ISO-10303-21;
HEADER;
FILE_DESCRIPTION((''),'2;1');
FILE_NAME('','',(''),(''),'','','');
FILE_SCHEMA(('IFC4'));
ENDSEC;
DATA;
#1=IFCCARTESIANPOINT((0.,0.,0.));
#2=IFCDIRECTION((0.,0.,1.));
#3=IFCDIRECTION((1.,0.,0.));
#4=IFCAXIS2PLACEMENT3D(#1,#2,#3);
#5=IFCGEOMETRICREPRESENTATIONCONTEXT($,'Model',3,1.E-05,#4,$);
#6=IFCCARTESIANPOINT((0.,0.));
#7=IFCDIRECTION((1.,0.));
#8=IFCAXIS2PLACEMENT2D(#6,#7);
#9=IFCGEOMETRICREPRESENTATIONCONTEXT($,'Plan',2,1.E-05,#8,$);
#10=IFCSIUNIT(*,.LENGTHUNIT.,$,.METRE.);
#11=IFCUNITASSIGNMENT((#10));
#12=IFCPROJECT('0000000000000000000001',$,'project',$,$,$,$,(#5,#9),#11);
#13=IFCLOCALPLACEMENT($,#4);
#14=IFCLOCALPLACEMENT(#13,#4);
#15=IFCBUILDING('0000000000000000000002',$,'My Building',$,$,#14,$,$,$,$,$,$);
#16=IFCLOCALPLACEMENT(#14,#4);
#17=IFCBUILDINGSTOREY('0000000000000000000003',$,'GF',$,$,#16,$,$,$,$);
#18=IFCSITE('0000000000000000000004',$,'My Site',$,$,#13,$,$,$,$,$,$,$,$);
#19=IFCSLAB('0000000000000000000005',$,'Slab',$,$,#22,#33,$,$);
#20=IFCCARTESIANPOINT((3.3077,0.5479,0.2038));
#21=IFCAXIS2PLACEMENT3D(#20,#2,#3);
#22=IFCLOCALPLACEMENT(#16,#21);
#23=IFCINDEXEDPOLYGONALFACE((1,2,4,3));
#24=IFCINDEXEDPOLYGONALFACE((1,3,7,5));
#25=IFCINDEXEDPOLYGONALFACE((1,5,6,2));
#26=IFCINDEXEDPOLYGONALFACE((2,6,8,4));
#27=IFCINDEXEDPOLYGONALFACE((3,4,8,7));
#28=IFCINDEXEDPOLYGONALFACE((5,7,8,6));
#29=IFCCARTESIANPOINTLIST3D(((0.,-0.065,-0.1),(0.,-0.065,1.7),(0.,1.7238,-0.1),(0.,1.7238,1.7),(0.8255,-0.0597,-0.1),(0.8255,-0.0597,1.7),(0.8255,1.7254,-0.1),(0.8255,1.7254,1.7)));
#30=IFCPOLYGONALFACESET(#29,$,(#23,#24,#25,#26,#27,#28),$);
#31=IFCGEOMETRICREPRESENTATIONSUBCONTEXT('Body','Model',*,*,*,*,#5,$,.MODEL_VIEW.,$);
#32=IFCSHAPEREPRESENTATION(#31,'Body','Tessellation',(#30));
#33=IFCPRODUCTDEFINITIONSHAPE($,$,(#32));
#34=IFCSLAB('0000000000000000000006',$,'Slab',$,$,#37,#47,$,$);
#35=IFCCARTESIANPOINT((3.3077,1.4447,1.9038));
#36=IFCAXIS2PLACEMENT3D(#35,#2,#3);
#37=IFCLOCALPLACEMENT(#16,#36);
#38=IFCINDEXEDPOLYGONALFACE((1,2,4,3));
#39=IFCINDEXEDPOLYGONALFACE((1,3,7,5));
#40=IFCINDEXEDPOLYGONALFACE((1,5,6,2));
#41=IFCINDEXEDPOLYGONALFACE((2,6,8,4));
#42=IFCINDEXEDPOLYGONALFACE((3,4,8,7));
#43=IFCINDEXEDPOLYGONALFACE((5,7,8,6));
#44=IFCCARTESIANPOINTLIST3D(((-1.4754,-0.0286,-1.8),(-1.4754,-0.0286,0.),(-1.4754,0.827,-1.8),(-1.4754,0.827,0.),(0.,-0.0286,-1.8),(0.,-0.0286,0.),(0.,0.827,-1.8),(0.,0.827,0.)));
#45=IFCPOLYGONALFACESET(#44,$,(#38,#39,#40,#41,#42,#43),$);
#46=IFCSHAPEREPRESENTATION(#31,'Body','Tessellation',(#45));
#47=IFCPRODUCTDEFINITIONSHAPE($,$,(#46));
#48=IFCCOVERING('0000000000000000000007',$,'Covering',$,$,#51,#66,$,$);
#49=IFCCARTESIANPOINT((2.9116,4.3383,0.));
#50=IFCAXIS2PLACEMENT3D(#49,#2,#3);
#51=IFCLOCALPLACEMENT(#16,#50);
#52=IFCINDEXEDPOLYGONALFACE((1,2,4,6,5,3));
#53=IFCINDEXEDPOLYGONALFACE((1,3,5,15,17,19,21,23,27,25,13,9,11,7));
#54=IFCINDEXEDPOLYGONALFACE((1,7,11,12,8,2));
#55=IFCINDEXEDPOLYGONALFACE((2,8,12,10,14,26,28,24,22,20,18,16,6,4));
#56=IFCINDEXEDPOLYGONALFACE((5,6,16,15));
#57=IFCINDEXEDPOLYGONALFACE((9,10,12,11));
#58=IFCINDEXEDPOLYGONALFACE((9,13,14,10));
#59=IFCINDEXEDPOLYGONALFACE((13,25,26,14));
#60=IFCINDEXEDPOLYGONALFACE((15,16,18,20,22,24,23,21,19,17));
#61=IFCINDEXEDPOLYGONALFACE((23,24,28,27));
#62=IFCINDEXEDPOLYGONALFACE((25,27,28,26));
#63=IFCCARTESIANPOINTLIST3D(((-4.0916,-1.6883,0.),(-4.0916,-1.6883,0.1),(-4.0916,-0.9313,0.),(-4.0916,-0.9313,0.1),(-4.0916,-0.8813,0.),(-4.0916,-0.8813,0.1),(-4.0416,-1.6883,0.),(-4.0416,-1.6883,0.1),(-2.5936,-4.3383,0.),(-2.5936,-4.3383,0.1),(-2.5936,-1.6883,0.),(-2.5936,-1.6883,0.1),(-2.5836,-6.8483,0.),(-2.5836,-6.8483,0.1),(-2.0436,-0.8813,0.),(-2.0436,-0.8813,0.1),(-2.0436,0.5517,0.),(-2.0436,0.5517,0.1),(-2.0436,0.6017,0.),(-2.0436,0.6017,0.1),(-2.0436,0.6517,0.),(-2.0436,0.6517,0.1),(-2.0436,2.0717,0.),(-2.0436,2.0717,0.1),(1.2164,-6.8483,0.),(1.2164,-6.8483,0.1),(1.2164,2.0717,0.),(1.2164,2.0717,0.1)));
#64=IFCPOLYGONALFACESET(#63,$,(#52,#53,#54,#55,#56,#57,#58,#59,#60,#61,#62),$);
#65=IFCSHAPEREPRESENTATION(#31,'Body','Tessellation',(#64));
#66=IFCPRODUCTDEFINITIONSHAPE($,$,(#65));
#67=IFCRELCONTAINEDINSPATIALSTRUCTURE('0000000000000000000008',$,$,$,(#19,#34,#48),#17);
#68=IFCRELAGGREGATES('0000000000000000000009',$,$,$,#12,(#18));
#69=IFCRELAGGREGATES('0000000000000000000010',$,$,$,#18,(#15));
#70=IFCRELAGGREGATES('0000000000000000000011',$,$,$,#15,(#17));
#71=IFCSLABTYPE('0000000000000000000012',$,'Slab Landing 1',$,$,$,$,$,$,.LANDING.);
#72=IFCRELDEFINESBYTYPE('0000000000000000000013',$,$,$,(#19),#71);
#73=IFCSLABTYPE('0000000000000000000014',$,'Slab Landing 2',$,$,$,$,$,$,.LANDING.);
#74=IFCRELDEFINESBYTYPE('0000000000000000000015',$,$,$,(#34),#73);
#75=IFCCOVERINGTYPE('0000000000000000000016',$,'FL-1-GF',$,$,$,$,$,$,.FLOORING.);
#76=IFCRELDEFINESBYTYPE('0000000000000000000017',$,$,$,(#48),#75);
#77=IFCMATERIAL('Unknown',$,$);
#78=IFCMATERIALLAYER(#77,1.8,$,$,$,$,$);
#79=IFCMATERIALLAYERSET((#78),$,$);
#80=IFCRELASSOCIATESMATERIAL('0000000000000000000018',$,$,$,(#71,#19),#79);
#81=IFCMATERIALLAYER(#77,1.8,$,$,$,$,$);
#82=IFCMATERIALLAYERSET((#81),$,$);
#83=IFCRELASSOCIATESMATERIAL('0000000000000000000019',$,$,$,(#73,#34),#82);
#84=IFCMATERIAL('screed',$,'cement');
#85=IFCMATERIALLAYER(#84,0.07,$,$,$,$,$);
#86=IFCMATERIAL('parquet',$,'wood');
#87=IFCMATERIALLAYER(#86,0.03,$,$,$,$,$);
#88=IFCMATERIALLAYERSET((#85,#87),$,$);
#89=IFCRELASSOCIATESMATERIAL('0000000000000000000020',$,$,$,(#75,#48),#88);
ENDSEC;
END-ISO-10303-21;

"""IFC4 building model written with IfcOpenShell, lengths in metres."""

from ifc_helpers import new_model, si_unit, frame, origin_with_axes, origin_2d_with_axis, place, context, subcontext, project, spatial, line, indexed_curve, outline, extrude, material, layer, layer_set, layer_usage, type_object, element, save


model = new_model("IFC4")

# Units and contexts
model_context = context("Model", 3, precision=1e-05, world=origin_with_axes())
plan_context = context("Plan", 2, precision=1e-05, world=origin_2d_with_axis())
body_context_1 = subcontext(model_context, "Body", "Model", "MODEL_VIEW")
ifc_project = project(units=[si_unit("LENGTHUNIT", "METRE")], contexts=[model_context, plan_context])

# Site, building, storey
site_placement = place(None, origin_with_axes())
site = spatial("IfcSite", under=ifc_project, at=site_placement, Name="My Site")
building_placement = place(site_placement, origin_with_axes())
building = spatial("IfcBuilding", under=site, at=building_placement, Name="My Building")
storey_placement = place(building_placement, origin_with_axes())
storey = spatial("IfcBuildingStorey", under=building, at=storey_placement, Name="GF")

# Slabs
ifc_material_1 = material(Name="Unknown")
ifc_layer_1 = layer(ifc_material_1, 1.8)
ifc_layer_set_1 = layer_set([ifc_layer_1])
ifc_layer_usage_1 = layer_usage(ifc_layer_set_1, "AXIS3", "POSITIVE", -0.1)
slab_type_1 = type_object("IfcSlabType", Name="Slab Landing 1", PredefinedType="LANDING", material=ifc_layer_set_1)
slab_1_placement = place(storey_placement, frame((3.3077, 0.5479, 0.2038), z_axis=(0.0, 0.0, 1.0), x_axis=(1.0, 0.0, 0.0)))
element("IfcSlab", 1, at=slab_1_placement, inside=storey, type_object=slab_type_1, material=ifc_layer_usage_1, Name="Slab", context=body_context_1, shape_type="SweptSolid", body=[
    extrude(outline(indexed_curve([(0.8255, -0.0597), (0.8255, 1.7254), (0.0, 1.7238), (0.0, -0.065), (0.8255, -0.0597)])), frame((0.0, 0.0, -0.1), z_axis=(0.0, 0.0, 1.0), x_axis=(1.0, 0.0, 0.0)), (0.0, 0.0, 1.0), 1.8),
])
ifc_layer_2 = layer(ifc_material_1, 1.8)
ifc_layer_set_2 = layer_set([ifc_layer_2])
ifc_layer_usage_2 = layer_usage(ifc_layer_set_2, "AXIS3", "POSITIVE", -1.8)
slab_type_2 = type_object("IfcSlabType", Name="Slab Landing 2", PredefinedType="LANDING", material=ifc_layer_set_2)
slab_2_placement = place(storey_placement, frame((3.3077, 1.4447, 1.9038), z_axis=(0.0, 0.0, 1.0), x_axis=(1.0, 0.0, 0.0)))
element("IfcSlab", 2, at=slab_2_placement, inside=storey, type_object=slab_type_2, material=ifc_layer_usage_2, Name="Slab", context=body_context_1, shape_type="SweptSolid", body=[
    extrude(outline(indexed_curve([(-1.4754, -0.0286), (-1.4754, 0.827), (0.0, 0.827), (0.0, -0.0286), (-1.4754, -0.0286)])), frame((0.0, 0.0, -1.8), z_axis=(0.0, 0.0, 1.0), x_axis=(1.0, 0.0, 0.0)), (0.0, 0.0, 1.0), 1.8),
])

# Covering
ifc_material_2 = material(Name="screed", Category="cement")
ifc_layer_3 = layer(ifc_material_2, 0.07)
ifc_material_3 = material(Name="parquet", Category="wood")
ifc_layer_4 = layer(ifc_material_3, 0.03)
ifc_layer_set_3 = layer_set([ifc_layer_3, ifc_layer_4])
ifc_layer_usage_3 = layer_usage(ifc_layer_set_3, "AXIS3", "POSITIVE", 0.0)
covering_type = type_object("IfcCoveringType", Name="FL-1-GF", PredefinedType="FLOORING", material=ifc_layer_set_3)
covering_placement = place(storey_placement, frame((2.9116, 4.3383, 0.0), z_axis=(0.0, 0.0, 1.0), x_axis=(1.0, 0.0, 0.0)))
element("IfcCovering", 3, at=covering_placement, inside=storey, type_object=covering_type, material=ifc_layer_usage_3, Name="Covering", context=body_context_1, shape_type="SweptSolid", body=[
    extrude(outline(indexed_curve([(-2.0436, 2.0717), (1.2164, 2.0717), (1.2164, -6.8483), (-2.5836, -6.8483), (-2.5936, -4.3383), (-2.5936, -1.6883), (-4.0416, -1.6883), (-4.0916, -1.6883), (-4.0916, -0.9313), (-4.0916, -0.8813), (-2.0436, -0.8813), (-2.0436, 0.5517), (-2.0436, 0.6017), (-2.0436, 0.6517)], segments=[line(1, 2, 3, 4, 5, 6, 7, 8, 9, 10, 11, 12, 13, 14, 1)])), origin_with_axes(), (0.0, 0.0, 1.0), 0.1),
])

save(model, "model.ifc")
